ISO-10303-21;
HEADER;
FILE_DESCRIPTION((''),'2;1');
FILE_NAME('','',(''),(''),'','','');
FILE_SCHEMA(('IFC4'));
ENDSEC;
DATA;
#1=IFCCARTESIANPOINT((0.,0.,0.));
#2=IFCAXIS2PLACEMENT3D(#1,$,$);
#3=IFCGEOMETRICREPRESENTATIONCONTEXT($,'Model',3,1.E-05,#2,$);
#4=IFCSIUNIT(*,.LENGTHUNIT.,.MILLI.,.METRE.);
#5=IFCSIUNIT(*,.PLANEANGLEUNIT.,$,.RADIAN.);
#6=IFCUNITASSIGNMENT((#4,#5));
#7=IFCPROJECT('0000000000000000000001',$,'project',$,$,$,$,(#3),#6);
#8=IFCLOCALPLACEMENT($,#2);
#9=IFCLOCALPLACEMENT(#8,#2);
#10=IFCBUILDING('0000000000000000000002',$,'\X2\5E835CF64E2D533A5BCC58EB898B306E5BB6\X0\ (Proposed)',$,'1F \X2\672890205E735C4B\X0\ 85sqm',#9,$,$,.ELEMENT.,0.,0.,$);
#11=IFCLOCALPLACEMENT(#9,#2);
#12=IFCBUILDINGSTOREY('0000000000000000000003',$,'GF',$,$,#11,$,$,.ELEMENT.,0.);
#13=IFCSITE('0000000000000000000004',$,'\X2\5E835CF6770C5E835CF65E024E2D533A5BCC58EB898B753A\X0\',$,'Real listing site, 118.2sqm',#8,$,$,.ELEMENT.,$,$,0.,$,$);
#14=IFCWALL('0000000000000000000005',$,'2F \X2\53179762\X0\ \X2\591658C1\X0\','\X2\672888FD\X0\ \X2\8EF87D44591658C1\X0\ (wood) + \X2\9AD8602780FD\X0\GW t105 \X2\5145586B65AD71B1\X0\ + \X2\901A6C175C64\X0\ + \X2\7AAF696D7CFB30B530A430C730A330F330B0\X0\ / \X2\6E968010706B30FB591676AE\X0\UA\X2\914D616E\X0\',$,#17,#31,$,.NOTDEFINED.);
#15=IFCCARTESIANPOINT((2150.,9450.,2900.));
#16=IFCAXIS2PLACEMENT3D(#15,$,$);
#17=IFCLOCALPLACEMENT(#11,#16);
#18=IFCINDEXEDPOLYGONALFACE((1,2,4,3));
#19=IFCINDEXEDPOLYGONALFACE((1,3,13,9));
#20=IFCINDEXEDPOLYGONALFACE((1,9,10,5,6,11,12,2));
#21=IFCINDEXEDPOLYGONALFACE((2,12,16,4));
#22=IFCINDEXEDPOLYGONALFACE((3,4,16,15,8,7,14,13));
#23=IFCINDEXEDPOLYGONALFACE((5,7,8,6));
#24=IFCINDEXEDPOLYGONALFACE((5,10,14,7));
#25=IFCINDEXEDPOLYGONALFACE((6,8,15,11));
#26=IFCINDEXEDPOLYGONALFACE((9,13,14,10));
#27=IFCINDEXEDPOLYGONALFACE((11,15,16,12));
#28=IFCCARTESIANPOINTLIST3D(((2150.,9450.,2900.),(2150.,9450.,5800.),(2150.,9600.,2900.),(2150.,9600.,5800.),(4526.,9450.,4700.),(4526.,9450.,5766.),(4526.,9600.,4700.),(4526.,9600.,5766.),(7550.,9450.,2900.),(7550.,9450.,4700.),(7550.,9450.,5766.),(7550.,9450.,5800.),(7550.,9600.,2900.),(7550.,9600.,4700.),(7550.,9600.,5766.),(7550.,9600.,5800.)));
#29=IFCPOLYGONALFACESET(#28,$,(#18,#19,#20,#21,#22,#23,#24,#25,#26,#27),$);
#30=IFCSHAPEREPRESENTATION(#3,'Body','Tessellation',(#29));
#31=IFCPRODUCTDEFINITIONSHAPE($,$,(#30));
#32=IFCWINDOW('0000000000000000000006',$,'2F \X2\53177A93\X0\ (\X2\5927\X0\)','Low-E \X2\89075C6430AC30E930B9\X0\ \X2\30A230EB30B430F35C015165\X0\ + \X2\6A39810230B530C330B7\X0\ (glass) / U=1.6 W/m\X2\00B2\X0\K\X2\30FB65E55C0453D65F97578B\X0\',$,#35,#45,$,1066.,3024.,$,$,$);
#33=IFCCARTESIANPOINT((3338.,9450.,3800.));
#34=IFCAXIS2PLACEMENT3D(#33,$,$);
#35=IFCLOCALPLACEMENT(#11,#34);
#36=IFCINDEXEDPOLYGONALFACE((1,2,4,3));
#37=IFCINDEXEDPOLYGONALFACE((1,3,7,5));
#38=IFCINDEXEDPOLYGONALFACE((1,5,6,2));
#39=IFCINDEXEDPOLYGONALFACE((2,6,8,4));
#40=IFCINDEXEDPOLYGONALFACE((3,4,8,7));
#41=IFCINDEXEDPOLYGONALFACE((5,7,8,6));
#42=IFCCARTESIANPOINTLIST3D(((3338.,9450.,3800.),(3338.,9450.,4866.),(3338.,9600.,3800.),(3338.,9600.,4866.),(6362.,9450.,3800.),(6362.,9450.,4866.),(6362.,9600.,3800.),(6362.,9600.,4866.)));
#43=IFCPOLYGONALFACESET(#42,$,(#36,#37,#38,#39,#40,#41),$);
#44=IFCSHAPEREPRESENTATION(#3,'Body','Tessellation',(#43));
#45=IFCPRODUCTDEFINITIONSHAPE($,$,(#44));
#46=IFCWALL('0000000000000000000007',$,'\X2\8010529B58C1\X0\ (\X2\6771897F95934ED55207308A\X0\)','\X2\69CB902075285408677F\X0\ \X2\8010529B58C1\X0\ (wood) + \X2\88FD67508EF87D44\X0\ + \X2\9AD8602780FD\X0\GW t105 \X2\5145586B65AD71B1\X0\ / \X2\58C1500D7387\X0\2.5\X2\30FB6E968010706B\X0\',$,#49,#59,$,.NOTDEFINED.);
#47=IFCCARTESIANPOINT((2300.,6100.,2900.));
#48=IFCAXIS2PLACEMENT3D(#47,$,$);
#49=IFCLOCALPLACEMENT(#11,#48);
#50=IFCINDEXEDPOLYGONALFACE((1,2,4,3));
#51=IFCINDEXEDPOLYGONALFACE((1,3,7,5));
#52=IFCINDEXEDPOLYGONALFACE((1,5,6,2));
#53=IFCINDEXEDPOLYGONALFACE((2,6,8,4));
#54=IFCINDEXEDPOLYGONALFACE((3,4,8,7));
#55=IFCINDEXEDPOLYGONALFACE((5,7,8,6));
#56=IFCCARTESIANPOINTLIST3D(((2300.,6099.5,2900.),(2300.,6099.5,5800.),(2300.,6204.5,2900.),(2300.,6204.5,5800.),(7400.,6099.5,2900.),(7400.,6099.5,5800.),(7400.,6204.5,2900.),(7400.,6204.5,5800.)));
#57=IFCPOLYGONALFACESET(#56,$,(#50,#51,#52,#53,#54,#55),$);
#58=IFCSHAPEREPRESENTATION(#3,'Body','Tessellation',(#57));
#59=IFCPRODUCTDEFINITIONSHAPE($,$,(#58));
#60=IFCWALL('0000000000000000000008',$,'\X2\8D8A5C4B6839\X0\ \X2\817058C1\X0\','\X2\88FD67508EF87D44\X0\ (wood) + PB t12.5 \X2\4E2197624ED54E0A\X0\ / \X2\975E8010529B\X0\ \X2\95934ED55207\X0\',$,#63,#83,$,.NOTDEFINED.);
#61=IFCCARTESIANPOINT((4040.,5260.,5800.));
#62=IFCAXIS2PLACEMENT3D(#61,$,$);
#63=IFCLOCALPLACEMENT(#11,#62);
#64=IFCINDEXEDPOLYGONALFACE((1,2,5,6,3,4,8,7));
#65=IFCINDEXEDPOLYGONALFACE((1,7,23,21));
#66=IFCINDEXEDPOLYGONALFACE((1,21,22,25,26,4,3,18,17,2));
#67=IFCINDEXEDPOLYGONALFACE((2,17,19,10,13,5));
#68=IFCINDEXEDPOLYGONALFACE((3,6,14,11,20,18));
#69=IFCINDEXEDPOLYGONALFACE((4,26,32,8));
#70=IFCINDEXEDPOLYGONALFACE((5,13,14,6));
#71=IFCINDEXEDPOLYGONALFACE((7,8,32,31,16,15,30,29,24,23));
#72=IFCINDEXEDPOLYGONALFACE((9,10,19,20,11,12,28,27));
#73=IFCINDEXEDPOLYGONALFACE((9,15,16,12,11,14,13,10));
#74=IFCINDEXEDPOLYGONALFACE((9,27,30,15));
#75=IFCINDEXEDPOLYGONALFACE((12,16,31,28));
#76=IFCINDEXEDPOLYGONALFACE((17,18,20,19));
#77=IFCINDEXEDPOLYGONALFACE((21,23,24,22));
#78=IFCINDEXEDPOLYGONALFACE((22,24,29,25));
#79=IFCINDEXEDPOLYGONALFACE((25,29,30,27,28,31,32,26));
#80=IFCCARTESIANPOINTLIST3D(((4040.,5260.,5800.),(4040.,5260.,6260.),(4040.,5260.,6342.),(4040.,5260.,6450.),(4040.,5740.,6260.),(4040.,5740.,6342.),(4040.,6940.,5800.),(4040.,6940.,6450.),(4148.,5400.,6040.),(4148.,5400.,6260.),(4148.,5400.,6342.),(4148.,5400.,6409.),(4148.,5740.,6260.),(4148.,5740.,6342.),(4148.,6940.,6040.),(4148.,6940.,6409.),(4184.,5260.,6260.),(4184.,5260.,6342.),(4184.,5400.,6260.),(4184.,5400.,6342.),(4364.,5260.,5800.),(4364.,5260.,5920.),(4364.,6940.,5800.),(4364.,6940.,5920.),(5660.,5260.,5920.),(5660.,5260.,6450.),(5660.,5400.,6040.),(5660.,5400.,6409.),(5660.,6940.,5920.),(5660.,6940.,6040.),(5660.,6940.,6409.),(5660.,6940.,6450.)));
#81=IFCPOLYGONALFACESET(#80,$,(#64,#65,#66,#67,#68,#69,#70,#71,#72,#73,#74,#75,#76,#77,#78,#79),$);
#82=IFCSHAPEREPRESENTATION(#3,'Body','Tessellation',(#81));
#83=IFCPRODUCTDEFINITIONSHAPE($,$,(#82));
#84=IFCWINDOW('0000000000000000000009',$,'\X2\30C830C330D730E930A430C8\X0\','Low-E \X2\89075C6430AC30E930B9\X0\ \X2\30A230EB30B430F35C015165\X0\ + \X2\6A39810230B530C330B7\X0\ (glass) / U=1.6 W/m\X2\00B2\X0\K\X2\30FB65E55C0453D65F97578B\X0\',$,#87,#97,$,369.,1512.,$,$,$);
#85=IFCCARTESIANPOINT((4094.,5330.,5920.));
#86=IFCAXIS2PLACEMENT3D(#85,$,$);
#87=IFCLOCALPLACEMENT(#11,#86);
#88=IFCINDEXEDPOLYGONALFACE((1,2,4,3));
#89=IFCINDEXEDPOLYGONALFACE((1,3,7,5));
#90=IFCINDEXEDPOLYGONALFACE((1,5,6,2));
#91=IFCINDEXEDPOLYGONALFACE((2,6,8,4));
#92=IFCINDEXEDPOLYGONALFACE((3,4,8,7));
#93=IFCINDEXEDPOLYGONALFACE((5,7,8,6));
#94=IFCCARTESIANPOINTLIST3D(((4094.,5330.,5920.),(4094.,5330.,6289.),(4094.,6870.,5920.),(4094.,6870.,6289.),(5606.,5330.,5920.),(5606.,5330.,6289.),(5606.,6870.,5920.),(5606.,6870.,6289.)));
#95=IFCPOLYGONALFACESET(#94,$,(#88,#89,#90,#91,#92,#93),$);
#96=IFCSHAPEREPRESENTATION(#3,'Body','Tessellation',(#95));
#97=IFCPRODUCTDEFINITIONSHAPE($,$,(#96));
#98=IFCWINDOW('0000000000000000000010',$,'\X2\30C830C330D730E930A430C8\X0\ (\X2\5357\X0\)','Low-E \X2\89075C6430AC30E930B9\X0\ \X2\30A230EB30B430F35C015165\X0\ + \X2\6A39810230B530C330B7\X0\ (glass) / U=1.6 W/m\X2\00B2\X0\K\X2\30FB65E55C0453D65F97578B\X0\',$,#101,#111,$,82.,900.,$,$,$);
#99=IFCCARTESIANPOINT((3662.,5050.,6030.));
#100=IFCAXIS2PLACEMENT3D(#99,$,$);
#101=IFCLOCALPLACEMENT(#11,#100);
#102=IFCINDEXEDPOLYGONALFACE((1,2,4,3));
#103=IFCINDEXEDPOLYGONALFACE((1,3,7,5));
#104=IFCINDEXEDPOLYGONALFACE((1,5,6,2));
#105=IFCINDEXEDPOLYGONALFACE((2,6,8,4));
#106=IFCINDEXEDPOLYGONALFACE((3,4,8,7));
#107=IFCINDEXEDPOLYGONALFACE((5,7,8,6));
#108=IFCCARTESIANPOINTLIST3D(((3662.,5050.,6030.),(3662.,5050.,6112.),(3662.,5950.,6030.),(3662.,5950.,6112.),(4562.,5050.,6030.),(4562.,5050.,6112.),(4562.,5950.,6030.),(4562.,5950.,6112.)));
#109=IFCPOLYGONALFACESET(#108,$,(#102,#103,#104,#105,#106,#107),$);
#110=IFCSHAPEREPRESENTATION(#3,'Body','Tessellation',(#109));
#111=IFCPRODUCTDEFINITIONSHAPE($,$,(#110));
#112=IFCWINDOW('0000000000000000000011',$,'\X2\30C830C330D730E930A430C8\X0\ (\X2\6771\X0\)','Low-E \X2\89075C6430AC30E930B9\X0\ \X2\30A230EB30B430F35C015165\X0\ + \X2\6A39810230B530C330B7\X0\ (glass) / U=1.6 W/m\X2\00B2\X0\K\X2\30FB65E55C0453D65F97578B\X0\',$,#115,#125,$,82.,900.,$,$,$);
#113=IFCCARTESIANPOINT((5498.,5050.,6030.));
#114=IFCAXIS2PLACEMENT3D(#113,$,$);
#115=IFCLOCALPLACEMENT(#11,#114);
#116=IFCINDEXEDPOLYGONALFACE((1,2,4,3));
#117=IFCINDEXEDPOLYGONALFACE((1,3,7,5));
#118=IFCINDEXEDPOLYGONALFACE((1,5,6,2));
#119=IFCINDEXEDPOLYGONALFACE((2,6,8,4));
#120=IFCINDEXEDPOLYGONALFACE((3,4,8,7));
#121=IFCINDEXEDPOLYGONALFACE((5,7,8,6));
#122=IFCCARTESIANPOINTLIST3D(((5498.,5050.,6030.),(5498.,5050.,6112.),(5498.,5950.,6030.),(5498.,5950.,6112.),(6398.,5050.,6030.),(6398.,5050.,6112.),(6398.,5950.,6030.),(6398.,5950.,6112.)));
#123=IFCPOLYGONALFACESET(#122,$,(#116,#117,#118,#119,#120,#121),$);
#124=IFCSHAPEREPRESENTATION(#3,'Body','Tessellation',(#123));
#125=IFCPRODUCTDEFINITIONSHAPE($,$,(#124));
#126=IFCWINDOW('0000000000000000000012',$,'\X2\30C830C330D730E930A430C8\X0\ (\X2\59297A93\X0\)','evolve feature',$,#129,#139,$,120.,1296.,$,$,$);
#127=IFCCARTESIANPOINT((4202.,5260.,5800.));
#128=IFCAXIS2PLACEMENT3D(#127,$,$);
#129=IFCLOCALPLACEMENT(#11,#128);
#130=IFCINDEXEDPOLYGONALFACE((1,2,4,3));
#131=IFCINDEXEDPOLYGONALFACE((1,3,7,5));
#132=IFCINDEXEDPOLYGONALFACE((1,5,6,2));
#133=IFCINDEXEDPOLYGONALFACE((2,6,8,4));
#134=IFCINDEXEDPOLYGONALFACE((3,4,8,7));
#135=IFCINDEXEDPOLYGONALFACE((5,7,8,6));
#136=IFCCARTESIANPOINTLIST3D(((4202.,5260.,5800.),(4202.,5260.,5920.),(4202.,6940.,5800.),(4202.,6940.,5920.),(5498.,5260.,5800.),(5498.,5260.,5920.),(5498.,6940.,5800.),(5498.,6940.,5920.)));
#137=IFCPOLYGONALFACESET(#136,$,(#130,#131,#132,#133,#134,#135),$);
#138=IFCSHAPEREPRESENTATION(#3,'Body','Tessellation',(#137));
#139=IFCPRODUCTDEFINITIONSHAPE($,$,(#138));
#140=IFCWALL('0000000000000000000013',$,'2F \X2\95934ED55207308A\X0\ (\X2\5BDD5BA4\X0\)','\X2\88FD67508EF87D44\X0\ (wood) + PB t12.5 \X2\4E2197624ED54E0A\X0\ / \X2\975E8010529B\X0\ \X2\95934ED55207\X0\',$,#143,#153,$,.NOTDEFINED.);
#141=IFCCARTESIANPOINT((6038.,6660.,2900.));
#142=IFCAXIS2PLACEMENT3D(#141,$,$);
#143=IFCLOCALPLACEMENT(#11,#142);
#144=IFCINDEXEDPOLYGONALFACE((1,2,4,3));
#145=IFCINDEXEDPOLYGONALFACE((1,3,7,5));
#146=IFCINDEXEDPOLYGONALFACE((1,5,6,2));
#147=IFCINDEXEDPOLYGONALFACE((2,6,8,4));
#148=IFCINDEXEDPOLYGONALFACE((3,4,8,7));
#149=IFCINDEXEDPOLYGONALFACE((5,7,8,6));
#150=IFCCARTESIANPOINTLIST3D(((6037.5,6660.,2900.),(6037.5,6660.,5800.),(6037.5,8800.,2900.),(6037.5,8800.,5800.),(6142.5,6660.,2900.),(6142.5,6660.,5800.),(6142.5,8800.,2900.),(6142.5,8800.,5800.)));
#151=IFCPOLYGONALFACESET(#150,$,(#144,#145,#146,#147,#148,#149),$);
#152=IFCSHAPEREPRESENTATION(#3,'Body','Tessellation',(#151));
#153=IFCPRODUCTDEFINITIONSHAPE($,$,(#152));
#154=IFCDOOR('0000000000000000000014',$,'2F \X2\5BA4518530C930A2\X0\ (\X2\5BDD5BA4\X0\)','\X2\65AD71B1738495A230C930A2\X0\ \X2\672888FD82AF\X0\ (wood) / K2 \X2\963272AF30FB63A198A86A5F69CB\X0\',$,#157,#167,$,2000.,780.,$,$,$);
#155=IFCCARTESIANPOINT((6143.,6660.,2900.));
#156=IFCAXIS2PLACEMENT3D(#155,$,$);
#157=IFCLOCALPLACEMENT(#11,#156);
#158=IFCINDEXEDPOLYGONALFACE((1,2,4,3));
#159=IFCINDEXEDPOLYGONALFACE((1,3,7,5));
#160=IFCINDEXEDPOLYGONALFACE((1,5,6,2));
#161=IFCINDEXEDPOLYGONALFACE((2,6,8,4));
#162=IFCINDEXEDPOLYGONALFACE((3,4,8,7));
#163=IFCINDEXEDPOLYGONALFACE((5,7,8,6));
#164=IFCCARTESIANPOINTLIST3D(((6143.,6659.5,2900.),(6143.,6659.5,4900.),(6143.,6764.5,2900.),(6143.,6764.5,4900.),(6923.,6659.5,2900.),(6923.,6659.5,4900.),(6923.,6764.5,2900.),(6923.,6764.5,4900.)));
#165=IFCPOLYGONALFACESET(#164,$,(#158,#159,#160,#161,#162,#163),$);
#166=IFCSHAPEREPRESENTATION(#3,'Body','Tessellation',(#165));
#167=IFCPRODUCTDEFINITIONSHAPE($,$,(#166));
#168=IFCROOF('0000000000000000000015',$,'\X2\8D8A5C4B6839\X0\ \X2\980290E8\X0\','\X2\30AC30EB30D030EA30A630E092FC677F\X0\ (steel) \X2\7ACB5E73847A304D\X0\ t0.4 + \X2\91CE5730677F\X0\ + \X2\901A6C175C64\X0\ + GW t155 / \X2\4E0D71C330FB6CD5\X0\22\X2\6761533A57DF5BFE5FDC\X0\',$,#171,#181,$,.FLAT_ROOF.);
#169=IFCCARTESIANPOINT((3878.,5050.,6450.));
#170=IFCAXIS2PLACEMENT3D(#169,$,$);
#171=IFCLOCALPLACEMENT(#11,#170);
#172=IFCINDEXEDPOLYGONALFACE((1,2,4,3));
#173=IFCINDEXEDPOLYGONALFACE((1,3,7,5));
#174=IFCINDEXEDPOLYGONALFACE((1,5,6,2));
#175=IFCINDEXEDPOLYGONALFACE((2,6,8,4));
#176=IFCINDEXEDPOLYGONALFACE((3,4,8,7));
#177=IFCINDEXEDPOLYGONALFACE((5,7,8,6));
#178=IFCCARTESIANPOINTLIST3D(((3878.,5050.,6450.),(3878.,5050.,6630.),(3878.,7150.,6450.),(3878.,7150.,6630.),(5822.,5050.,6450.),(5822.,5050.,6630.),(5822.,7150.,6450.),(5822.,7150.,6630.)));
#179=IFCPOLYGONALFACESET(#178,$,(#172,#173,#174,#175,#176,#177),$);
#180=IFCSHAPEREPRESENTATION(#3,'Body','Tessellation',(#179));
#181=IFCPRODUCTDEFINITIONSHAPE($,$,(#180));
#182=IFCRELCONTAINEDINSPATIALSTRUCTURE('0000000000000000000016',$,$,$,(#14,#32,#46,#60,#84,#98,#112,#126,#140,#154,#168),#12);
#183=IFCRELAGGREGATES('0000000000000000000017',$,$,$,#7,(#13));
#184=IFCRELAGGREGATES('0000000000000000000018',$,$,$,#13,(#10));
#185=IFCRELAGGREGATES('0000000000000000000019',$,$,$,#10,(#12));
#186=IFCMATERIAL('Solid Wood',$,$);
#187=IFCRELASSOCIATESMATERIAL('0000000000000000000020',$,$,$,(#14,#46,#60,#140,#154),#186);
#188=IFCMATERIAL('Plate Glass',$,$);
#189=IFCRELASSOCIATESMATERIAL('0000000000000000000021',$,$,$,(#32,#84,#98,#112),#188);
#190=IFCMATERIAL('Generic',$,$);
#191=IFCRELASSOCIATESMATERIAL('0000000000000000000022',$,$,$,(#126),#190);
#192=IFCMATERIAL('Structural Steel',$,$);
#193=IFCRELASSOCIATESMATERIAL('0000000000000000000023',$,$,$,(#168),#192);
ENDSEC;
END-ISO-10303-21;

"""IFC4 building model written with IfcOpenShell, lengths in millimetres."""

from ifc_helpers import new_model, si_unit, frame, frame_2d, origin, place, context, project, spatial, rectangle, extrude, material, element, fill, save


model = new_model("IFC4")

# Units and contexts
model_context = context("Model", 3, precision=1e-05, world=origin())
ifc_project = project(units=[si_unit("LENGTHUNIT", "METRE", prefix="MILLI"), si_unit("PLANEANGLEUNIT", "RADIAN")], contexts=[model_context])

# Site, building, storey
site_placement = place(None, origin())
site = spatial("IfcSite", under=ifc_project, at=site_placement, Name="広島県広島市中区富士見町", ObjectType="Real listing site, 118.2sqm", CompositionType="ELEMENT", RefElevation=0.0)
building_placement = place(site_placement, origin())
building = spatial("IfcBuilding", under=site, at=building_placement, Name="広島中区富士見の家 (Proposed)", ObjectType="1F 木造平屋 85sqm", CompositionType="ELEMENT", ElevationOfRefHeight=0.0, ElevationOfTerrain=0.0)
storey_placement = place(building_placement, origin())
storey = spatial("IfcBuildingStorey", under=building, at=storey_placement, Name="GF", CompositionType="ELEMENT", Elevation=0.0)

# Wall, opening, window
ifc_material_1 = material(Name="Solid Wood")
wall_1_placement = place(storey_placement, frame((2150.0, 9450.0, 2900.0)))
wall_1 = element("IfcWall", 1, at=wall_1_placement, inside=storey, material=ifc_material_1, Name="2F 北面 外壁", Description="木製 軸組外壁 (wood) + 高性能GW t105 充填断熱 + 通気層 + 窯業系サイディング / 準耐火・外皮UA配慮", PredefinedType="NOTDEFINED", context=model_context, shape_type="SweptSolid", body=[
    extrude(rectangle(XDim=5400.0, YDim=150.0, at=frame_2d((2700.0, 75.0))), frame((2150.0, 9450.0, 2900.0)), (0.0, 0.0, 1.0), 2900.0),
])
opening_1_placement = place(storey_placement, frame((3338.0, 9450.0, 3800.0)))
opening_1 = element("IfcOpeningElement", 2, at=opening_1_placement, cuts=wall_1, PredefinedType="NOTDEFINED", context=model_context, shape_type="SweptSolid", body=[
    extrude(rectangle(XDim=3024.0, YDim=150.0, at=frame_2d((1512.0, 75.0))), frame((3338.0, 9450.0, 3800.0)), (0.0, 0.0, 1.0), 1066.0),
])
ifc_material_2 = material(Name="Plate Glass")
window_1_placement = place(storey_placement, frame((3338.0, 9450.0, 3800.0)))
window_1 = element("IfcWindow", 3, at=window_1_placement, inside=storey, material=ifc_material_2, Name="2F 北窓 (大)", Description="Low-E 複層ガラス アルゴン封入 + 樹脂サッシ (glass) / U=1.6 W/m²K・日射取得型", OverallHeight=1066.0, OverallWidth=3024.0, context=model_context, shape_type="SweptSolid", body=[
    extrude(rectangle(XDim=3024.0, YDim=150.0, at=frame_2d((1512.0, 75.0))), frame((3338.0, 9450.0, 3800.0)), (0.0, 0.0, 1.0), 1066.0),
])
fill(opening_1, window_1)

# Wall
wall_2_placement = place(storey_placement, frame((2300.0, 6100.0, 2900.0)))
element("IfcWall", 4, at=wall_2_placement, inside=storey, material=ifc_material_1, Name="耐力壁 (東西間仕切り)", Description="構造用合板 耐力壁 (wood) + 製材軸組 + 高性能GW t105 充填断熱 / 壁倍率2.5・準耐火", PredefinedType="NOTDEFINED", context=model_context, shape_type="SweptSolid", body=[
    extrude(rectangle(XDim=5100.0, YDim=105.0, at=frame_2d((2550.0, 52.0))), frame((2300.0, 6100.0, 2900.0)), (0.0, 0.0, 1.0), 2900.0),
])

# Wall, openings, windows
wall_3_placement = place(storey_placement, frame((4040.0, 5260.0, 5800.0)))
wall_3 = element("IfcWall", 5, at=wall_3_placement, inside=storey, material=ifc_material_1, Name="越屋根 腰壁", Description="製材軸組 (wood) + PB t12.5 両面仕上 / 非耐力 間仕切", PredefinedType="NOTDEFINED", context=model_context, shape_type="SweptSolid", body=[
    extrude(rectangle(XDim=1620.0, YDim=1680.0, at=frame_2d((810.0, 840.0))), frame((4040.0, 5260.0, 5800.0)), (0.0, 0.0, 1.0), 650.0),
])
opening_2_placement = place(storey_placement, frame((4094.0, 5330.0, 5920.0)))
opening_2 = element("IfcOpeningElement", 6, at=opening_2_placement, cuts=wall_3, PredefinedType="NOTDEFINED", context=model_context, shape_type="SweptSolid", body=[
    extrude(rectangle(XDim=1512.0, YDim=1540.0, at=frame_2d((756.0, 770.0))), frame((4094.0, 5330.0, 5920.0)), (0.0, 0.0, 1.0), 369.0),
])
opening_3_placement = place(storey_placement, frame((3662.0, 5050.0, 6030.0)))
opening_3 = element("IfcOpeningElement", 7, at=opening_3_placement, cuts=wall_3, PredefinedType="NOTDEFINED", context=model_context, shape_type="SweptSolid", body=[
    extrude(rectangle(XDim=900.0, YDim=900.0, at=frame_2d((450.0, 450.0))), frame((3662.0, 5050.0, 6030.0)), (0.0, 0.0, 1.0), 82.0),
])
opening_4_placement = place(storey_placement, frame((5498.0, 5050.0, 6030.0)))
opening_4 = element("IfcOpeningElement", 8, at=opening_4_placement, cuts=wall_3, PredefinedType="NOTDEFINED", context=model_context, shape_type="SweptSolid", body=[
    extrude(rectangle(XDim=900.0, YDim=900.0, at=frame_2d((450.0, 450.0))), frame((5498.0, 5050.0, 6030.0)), (0.0, 0.0, 1.0), 82.0),
])
opening_5_placement = place(storey_placement, frame((4202.0, 5260.0, 5800.0)))
opening_5 = element("IfcOpeningElement", 9, at=opening_5_placement, cuts=wall_3, PredefinedType="NOTDEFINED", context=model_context, shape_type="SweptSolid", body=[
    extrude(rectangle(XDim=1296.0, YDim=1680.0, at=frame_2d((648.0, 840.0))), frame((4202.0, 5260.0, 5800.0)), (0.0, 0.0, 1.0), 120.0),
])
window_2_placement = place(storey_placement, frame((4094.0, 5330.0, 5920.0)))
window_2 = element("IfcWindow", 10, at=window_2_placement, inside=storey, material=ifc_material_2, Name="トップライト", Description="Low-E 複層ガラス アルゴン封入 + 樹脂サッシ (glass) / U=1.6 W/m²K・日射取得型", OverallHeight=369.0, OverallWidth=1512.0, context=model_context, shape_type="SweptSolid", body=[
    extrude(rectangle(XDim=1512.0, YDim=1540.0, at=frame_2d((756.0, 770.0))), frame((4094.0, 5330.0, 5920.0)), (0.0, 0.0, 1.0), 369.0),
])
fill(opening_2, window_2)
window_3_placement = place(storey_placement, frame((3662.0, 5050.0, 6030.0)))
window_3 = element("IfcWindow", 11, at=window_3_placement, inside=storey, material=ifc_material_2, Name="トップライト (南)", Description="Low-E 複層ガラス アルゴン封入 + 樹脂サッシ (glass) / U=1.6 W/m²K・日射取得型", OverallHeight=82.0, OverallWidth=900.0, context=model_context, shape_type="SweptSolid", body=[
    extrude(rectangle(XDim=900.0, YDim=900.0, at=frame_2d((450.0, 450.0))), frame((3662.0, 5050.0, 6030.0)), (0.0, 0.0, 1.0), 82.0),
])
fill(opening_3, window_3)
window_4_placement = place(storey_placement, frame((5498.0, 5050.0, 6030.0)))
window_4 = element("IfcWindow", 12, at=window_4_placement, inside=storey, material=ifc_material_2, Name="トップライト (東)", Description="Low-E 複層ガラス アルゴン封入 + 樹脂サッシ (glass) / U=1.6 W/m²K・日射取得型", OverallHeight=82.0, OverallWidth=900.0, context=model_context, shape_type="SweptSolid", body=[
    extrude(rectangle(XDim=900.0, YDim=900.0, at=frame_2d((450.0, 450.0))), frame((5498.0, 5050.0, 6030.0)), (0.0, 0.0, 1.0), 82.0),
])
fill(opening_4, window_4)
ifc_material_3 = material(Name="Generic")
window_5_placement = place(storey_placement, frame((4202.0, 5260.0, 5800.0)))
window_5 = element("IfcWindow", 13, at=window_5_placement, inside=storey, material=ifc_material_3, Name="トップライト (天窓)", Description="evolve feature", OverallHeight=120.0, OverallWidth=1296.0, context=model_context, shape_type="SweptSolid", body=[
    extrude(rectangle(XDim=1296.0, YDim=1680.0, at=frame_2d((648.0, 840.0))), frame((4202.0, 5260.0, 5800.0)), (0.0, 0.0, 1.0), 120.0),
])
fill(opening_5, window_5)

# Wall
wall_4_placement = place(storey_placement, frame((6038.0, 6660.0, 2900.0)))
element("IfcWall", 14, at=wall_4_placement, inside=storey, material=ifc_material_1, Name="2F 間仕切り (寝室)", Description="製材軸組 (wood) + PB t12.5 両面仕上 / 非耐力 間仕切", PredefinedType="NOTDEFINED", context=model_context, shape_type="SweptSolid", body=[
    extrude(rectangle(XDim=105.0, YDim=2140.0, at=frame_2d((52.0, 1070.0))), frame((6038.0, 6660.0, 2900.0)), (0.0, 0.0, 1.0), 2900.0),
])

# Door
door_placement = place(storey_placement, frame((6143.0, 6660.0, 2900.0)))
element("IfcDoor", 15, at=door_placement, inside=storey, material=ifc_material_1, Name="2F 室内ドア (寝室)", Description="断熱玄関ドア 木製芯 (wood) / K2 防犯・採風機構", OverallHeight=2000.0, OverallWidth=780.0, context=model_context, shape_type="SweptSolid", body=[
    extrude(rectangle(XDim=780.0, YDim=105.0, at=frame_2d((390.0, 52.0))), frame((6143.0, 6660.0, 2900.0)), (0.0, 0.0, 1.0), 2000.0),
])

# Roof
ifc_material_4 = material(Name="Structural Steel")
roof_placement = place(storey_placement, frame((3878.0, 5050.0, 6450.0)))
element("IfcRoof", 16, at=roof_placement, inside=storey, material=ifc_material_4, Name="越屋根 頂部", Description="ガルバリウム鋼板 (steel) 立平葺き t0.4 + 野地板 + 通気層 + GW t155 / 不燃・法22条区域対応", PredefinedType="FLAT_ROOF", context=model_context, shape_type="SweptSolid", body=[
    extrude(rectangle(XDim=1944.0, YDim=2100.0, at=frame_2d((972.0, 1050.0))), frame((3878.0, 5050.0, 6450.0)), (0.0, 0.0, 1.0), 180.0),
])

save(model, "model.ifc")
